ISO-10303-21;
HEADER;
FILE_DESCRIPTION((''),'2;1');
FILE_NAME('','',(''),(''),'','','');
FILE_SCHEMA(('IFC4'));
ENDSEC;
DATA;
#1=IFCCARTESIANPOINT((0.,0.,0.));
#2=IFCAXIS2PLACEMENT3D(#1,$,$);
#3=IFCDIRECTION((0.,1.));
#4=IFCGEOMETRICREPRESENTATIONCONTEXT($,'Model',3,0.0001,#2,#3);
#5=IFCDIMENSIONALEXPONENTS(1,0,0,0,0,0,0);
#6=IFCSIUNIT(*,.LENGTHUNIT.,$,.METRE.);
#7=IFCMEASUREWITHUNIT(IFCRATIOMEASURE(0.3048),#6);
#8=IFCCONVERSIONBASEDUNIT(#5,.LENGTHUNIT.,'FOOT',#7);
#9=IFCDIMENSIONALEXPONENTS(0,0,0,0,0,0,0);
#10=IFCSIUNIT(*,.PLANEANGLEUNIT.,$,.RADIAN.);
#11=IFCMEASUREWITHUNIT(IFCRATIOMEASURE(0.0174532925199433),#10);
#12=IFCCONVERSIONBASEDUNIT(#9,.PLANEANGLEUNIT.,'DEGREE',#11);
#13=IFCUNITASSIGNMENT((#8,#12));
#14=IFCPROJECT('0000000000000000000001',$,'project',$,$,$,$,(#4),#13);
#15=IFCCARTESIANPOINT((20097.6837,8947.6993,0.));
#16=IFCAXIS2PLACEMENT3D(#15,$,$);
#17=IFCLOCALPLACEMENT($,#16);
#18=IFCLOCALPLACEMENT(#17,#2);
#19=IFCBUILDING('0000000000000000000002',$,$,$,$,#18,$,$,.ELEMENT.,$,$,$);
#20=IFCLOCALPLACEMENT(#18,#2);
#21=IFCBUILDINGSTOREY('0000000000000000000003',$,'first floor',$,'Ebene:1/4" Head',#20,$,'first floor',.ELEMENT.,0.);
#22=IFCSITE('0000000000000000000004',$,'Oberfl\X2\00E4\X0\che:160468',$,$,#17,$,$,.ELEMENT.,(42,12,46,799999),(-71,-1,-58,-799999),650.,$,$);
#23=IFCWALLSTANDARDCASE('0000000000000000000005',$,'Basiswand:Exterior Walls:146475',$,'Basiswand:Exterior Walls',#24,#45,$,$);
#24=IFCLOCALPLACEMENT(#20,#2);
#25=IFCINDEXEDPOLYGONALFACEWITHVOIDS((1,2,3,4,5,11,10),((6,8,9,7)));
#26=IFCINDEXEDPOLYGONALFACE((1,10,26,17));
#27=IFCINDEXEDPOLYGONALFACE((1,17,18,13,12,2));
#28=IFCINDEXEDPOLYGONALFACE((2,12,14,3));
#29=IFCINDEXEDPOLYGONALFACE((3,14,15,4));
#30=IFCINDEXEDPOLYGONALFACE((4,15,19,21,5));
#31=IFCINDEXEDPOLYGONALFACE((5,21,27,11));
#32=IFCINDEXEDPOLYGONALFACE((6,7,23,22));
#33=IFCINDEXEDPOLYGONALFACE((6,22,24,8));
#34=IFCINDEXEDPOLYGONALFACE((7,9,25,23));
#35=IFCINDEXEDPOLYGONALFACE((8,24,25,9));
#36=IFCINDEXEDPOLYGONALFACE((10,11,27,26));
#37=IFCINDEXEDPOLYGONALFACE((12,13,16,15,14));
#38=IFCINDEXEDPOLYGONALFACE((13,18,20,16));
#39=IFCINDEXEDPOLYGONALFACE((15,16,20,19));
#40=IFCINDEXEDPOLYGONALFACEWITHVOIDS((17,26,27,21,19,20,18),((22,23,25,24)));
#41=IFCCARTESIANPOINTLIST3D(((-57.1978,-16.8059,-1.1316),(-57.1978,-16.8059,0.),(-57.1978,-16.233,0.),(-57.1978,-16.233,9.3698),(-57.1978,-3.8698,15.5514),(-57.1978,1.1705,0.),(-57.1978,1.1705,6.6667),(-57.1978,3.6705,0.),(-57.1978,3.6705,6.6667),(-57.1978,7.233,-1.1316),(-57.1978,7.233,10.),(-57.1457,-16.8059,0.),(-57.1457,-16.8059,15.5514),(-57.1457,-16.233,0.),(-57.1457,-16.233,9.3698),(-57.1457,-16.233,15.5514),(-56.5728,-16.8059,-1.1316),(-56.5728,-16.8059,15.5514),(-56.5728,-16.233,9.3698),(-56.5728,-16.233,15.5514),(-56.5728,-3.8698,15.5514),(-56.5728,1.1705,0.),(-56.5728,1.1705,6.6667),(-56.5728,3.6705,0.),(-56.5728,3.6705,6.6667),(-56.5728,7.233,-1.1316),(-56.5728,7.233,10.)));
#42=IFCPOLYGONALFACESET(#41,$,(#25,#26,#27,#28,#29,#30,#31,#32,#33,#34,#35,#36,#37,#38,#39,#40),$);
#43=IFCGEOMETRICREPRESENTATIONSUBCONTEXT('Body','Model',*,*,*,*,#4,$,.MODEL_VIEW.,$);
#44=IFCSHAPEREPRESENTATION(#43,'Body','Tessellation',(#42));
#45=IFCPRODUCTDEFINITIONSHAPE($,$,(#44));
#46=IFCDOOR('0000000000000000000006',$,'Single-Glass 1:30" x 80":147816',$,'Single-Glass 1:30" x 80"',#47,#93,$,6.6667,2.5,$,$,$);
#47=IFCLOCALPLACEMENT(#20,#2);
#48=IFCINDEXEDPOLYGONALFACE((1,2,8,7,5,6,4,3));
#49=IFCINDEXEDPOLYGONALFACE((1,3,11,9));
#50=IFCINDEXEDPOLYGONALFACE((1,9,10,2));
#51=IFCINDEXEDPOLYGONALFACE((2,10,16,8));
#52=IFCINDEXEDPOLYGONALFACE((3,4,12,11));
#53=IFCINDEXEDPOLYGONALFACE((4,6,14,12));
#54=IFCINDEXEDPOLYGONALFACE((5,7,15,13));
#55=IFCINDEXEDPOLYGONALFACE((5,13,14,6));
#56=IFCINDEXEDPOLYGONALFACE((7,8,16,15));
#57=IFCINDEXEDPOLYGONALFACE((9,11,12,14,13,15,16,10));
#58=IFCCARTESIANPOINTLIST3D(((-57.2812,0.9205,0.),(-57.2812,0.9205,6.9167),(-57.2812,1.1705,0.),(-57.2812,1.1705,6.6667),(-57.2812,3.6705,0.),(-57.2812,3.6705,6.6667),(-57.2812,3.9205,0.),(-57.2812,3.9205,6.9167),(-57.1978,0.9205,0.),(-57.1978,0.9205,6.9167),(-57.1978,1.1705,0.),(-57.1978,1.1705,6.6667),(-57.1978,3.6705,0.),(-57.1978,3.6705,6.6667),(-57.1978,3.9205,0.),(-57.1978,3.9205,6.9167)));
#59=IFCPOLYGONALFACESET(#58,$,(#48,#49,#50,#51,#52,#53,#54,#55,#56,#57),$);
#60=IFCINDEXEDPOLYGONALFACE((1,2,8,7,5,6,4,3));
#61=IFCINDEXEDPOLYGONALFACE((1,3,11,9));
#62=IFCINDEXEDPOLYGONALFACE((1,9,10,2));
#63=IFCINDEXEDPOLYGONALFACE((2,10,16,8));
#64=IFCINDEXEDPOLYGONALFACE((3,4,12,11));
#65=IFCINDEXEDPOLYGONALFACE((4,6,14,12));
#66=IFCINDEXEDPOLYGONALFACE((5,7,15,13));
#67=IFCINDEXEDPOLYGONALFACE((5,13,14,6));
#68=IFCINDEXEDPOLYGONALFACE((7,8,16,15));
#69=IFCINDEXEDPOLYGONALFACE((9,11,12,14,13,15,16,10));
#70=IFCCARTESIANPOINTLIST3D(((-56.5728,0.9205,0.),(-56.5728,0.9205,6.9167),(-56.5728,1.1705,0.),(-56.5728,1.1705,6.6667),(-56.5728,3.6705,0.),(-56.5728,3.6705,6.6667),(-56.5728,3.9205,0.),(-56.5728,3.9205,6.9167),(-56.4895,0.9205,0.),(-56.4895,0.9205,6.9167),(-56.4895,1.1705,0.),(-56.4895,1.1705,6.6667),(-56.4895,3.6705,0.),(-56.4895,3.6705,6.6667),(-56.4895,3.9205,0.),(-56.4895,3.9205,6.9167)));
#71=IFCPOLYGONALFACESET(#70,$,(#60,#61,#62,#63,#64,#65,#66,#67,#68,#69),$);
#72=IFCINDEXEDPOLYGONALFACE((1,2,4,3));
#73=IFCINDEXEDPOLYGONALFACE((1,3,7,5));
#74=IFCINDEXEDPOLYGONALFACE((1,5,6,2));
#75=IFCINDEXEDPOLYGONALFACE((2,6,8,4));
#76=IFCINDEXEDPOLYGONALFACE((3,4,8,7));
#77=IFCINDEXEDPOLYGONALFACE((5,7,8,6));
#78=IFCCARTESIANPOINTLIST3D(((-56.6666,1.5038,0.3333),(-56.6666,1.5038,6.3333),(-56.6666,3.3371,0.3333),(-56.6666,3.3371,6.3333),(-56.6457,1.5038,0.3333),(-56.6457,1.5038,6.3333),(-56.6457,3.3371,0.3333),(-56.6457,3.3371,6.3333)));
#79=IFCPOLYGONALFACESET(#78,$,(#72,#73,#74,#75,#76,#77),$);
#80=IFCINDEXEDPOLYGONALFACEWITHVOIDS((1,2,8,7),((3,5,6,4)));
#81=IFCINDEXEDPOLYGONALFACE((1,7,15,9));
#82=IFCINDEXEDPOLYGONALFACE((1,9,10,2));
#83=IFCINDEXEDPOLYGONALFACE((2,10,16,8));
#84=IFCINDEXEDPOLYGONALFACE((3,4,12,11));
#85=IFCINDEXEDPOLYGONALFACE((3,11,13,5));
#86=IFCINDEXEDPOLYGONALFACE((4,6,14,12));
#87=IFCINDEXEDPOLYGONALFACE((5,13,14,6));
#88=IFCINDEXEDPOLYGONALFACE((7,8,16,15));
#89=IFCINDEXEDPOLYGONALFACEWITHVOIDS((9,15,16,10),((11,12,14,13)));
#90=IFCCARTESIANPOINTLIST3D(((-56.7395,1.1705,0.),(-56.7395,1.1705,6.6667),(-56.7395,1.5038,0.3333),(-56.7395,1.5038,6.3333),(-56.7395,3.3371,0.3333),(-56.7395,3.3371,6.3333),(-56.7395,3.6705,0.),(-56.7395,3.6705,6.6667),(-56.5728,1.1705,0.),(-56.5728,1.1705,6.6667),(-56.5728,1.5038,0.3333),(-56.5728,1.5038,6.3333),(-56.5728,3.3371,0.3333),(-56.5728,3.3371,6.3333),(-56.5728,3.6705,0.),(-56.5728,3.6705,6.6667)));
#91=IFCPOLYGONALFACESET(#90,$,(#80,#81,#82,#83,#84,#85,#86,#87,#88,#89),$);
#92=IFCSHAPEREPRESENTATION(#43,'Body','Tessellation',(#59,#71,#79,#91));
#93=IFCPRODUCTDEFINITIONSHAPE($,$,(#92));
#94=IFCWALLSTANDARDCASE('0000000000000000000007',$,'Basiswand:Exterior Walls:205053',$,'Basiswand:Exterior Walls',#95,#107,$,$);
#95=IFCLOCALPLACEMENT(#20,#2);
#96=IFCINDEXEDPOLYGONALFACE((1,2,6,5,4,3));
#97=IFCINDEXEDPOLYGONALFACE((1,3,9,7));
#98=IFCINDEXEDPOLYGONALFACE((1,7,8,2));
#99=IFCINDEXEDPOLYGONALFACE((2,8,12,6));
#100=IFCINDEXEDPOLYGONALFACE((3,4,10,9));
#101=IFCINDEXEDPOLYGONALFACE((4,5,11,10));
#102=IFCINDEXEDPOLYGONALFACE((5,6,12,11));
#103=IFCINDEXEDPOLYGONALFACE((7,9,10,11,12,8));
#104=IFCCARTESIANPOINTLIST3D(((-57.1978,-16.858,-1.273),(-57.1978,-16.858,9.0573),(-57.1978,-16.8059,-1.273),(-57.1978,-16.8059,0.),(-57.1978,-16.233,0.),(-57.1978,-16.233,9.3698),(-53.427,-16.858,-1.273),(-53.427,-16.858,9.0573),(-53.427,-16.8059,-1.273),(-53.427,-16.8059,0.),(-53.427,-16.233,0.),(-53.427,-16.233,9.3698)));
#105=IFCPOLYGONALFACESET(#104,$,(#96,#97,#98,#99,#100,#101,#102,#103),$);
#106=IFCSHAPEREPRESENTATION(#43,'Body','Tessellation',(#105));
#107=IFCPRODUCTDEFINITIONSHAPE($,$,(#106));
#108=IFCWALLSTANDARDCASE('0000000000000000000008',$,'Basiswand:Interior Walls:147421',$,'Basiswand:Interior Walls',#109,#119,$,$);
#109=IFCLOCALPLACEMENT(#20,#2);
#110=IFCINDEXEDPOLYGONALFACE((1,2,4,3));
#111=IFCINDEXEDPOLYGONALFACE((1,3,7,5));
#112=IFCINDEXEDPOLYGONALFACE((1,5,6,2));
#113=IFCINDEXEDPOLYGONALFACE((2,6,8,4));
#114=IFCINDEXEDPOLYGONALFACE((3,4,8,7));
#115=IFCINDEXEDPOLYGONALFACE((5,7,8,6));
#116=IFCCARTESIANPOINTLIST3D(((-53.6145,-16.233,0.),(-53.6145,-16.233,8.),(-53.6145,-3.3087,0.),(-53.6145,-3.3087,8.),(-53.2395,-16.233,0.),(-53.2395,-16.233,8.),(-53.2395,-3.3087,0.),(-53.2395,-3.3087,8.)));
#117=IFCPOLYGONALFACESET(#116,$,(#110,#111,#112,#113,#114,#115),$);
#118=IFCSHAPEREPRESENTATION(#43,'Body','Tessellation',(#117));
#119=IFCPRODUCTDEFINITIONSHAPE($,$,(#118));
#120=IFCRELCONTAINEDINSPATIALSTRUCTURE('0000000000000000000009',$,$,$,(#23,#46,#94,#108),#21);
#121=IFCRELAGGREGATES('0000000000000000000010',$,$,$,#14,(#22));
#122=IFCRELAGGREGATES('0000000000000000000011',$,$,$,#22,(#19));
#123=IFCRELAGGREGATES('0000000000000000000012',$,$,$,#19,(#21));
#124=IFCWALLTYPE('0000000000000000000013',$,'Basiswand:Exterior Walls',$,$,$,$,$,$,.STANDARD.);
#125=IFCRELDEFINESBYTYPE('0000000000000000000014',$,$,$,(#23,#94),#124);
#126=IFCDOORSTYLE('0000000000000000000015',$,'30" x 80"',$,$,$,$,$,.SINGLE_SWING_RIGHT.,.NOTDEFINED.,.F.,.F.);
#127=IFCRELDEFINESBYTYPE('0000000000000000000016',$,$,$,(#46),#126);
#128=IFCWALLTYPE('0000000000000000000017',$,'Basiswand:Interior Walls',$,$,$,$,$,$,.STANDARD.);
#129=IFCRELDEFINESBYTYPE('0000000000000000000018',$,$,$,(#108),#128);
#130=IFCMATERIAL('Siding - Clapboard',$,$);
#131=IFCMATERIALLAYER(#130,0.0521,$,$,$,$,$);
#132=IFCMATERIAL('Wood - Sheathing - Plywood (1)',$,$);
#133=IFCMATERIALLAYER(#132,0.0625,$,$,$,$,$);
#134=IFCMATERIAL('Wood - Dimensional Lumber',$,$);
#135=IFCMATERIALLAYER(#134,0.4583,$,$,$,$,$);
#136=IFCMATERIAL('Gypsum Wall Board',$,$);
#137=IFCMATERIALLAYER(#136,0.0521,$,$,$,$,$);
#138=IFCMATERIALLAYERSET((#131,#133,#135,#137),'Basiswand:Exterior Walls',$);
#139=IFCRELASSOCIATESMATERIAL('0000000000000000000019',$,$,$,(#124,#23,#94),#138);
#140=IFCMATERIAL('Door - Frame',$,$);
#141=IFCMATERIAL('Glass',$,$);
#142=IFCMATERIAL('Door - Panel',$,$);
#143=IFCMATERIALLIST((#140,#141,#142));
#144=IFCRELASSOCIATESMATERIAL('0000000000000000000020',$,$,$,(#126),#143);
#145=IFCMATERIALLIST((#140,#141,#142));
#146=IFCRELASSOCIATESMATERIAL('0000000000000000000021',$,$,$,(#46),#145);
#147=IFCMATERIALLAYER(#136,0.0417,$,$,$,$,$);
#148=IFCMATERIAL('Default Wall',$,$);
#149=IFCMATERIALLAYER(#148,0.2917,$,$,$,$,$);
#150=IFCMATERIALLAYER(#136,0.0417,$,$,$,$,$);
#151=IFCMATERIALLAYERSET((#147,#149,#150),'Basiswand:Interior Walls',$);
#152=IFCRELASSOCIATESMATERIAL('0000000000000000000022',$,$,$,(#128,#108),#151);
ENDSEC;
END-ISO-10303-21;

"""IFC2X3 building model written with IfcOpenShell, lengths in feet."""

from ifc_helpers import new_model, entity, si_unit, converted_unit, direction, frame, frame_2d, origin, place, context, subcontext, project, spatial, polyline, rectangle, outline, extrude, clip, bounded_halfspace, source, transform, mapped, material, material_list, layer, layer_set, layer_usage, type_object, type_shapes, element, fill, save


model = new_model("IFC2X3")

# Units and contexts
model_context = context("Model", 3, precision=0.0001, world=origin(), true_north=direction((0.0, 1.0)))
body_context = subcontext(model_context, "Body", "Model", "MODEL_VIEW")
ifc_project = project(units=[converted_unit("LENGTHUNIT", "FOOT", entity("IfcRatioMeasure", 0.3048), si_unit("LENGTHUNIT", "METRE"), dimensions=[1, 0, 0, 0, 0, 0, 0]), converted_unit("PLANEANGLEUNIT", "DEGREE", entity("IfcRatioMeasure", 0.0174532925199433), si_unit("PLANEANGLEUNIT", "RADIAN"), dimensions=[0, 0, 0, 0, 0, 0, 0])], contexts=[model_context])

# Site, building, storey
site_placement = place(None, frame((20097.6837, 8947.6993, 0.0)))
site = spatial("IfcSite", under=ifc_project, at=site_placement, Name="Oberfläche:160468", CompositionType="ELEMENT", RefLatitude=(42, 12, 46, 799999), RefLongitude=(-71, -1, -58, -799999), RefElevation=650.0)
building_placement = place(site_placement, origin())
building = spatial("IfcBuilding", under=site, at=building_placement, CompositionType="ELEMENT")
storey_placement = place(building_placement, origin())
storey = spatial("IfcBuildingStorey", under=building, at=storey_placement, Name="first floor", ObjectType="Ebene:1/4\" Head", LongName="first floor", CompositionType="ELEMENT", Elevation=0.0)

# Wall, opening, door
ifc_material_1 = material(Name="Siding - Clapboard")
ifc_layer_1 = layer(ifc_material_1, 0.0521)
ifc_material_2 = material(Name="Wood - Sheathing - Plywood (1)")
ifc_layer_2 = layer(ifc_material_2, 0.0625)
ifc_material_3 = material(Name="Wood - Dimensional Lumber")
ifc_layer_3 = layer(ifc_material_3, 0.4583)
ifc_material_4 = material(Name="Gypsum Wall Board")
ifc_layer_4 = layer(ifc_material_4, 0.0521)
ifc_layer_set_1 = layer_set([ifc_layer_1, ifc_layer_2, ifc_layer_3, ifc_layer_4], Name="Basiswand:Exterior Walls")
ifc_layer_usage_1 = layer_usage(ifc_layer_set_1, "AXIS2", "NEGATIVE", 0.3125)
wall_type_1 = type_object("IfcWallType", Name="Basiswand:Exterior Walls", PredefinedType="STANDARD", material=ifc_layer_set_1)
wall_1_placement = place(storey_placement, frame((-56.8853, -16.8059, -1.1316), z_axis=(0.0, 0.0, 1.0), x_axis=(0.0, 1.0, 0.0)))
wall_1 = element("IfcWallStandardCase", 1, at=wall_1_placement, inside=storey, type_object=wall_type_1, material=ifc_layer_usage_1, Name="Basiswand:Exterior Walls:146475", ObjectType="Basiswand:Exterior Walls", context=body_context, shape_type="Clipping", body=[
    clip(clip(clip(extrude(rectangle(XDim=24.0388, YDim=0.625, at=frame_2d((12.0194, 0.0), x_axis=(-1.0, 0.0))), origin(), (0.0, 0.0, 1.0), 16.683), bounded_halfspace(frame((12.9361, -0.3125, 16.683), z_axis=(0.447214, 0.0, 0.894427), x_axis=(0.0, 1.0, 0.0)), False, frame((12.9361, -0.3125, 16.683)), polyline([(0.0, 0.0), (10.4778, 0.0), (11.1028, 0.0), (11.1028, 0.625), (0.0, 0.625), (0.0, 0.0)]))), bounded_halfspace(frame((0.5729, -0.3125, 10.5014), z_axis=(-0.447214, 0.0, 0.894427), x_axis=(0.0, -1.0, 0.0)), False, frame((0.5729, -0.3125, 10.5014)), polyline([(0.0, 0.0), (12.3632, 0.0), (12.3632, 0.625), (0.0, 0.625), (0.0, 0.0)]))), bounded_halfspace(frame((0.0, 0.2604, 1.1316)), False, frame((0.0, 0.2604, 1.1316)), polyline([(0.0, 0.0), (0.5729, 0.0), (0.5729, 0.0521), (0.0, 0.0521), (0.0, 0.0)]))),
])
opening_1_placement = place(wall_1_placement, frame((20.4763, 0.3125, 1.1316)))
opening_1 = element("IfcOpeningElement", 2, at=opening_1_placement, cuts=wall_1, ObjectType="Opening", context=body_context, shape_type="SweptSolid", body=[
    extrude(rectangle(XDim=2.5, YDim=6.6667, at=frame_2d((3.3333, 1.25), x_axis=(0.0, 1.0))), frame((0.0, 0.0, 0.0), z_axis=(0.0, -1.0, 0.0), x_axis=(0.0, 0.0, 1.0)), (0.0, 0.0, 1.0), 0.625),
])
ifc_material_5 = material(Name="Door - Frame")
ifc_material_6 = material(Name="Glass")
ifc_material_7 = material(Name="Door - Panel")
ifc_material_list_1 = material_list([ifc_material_5, ifc_material_6, ifc_material_7])
ifc_material_list_2 = material_list([ifc_material_5, ifc_material_6, ifc_material_7])
door_style_1 = type_object("IfcDoorStyle", Name="30\" x 80\"", ConstructionType="NOTDEFINED", OperationType="SINGLE_SWING_RIGHT", ParameterTakesPrecedence=False, Sizeable=False, material=ifc_material_list_2)
shared_shape_1 = source(origin(), body_context, "Body", "SweptSolid", [
    extrude(outline(polyline([(-1.25, -3.2708), (-1.25, 3.3958), (-1.5, 3.3958), (-1.5, -3.5208), (1.5, -3.5208), (1.5, 3.3958), (1.25, 3.3958), (1.25, -3.2708), (-1.25, -3.2708)])), frame((1.25, -0.0833, 3.3958), z_axis=(0.0, -1.0, 0.0), x_axis=(-1.0, 0.0, 0.0)), (0.0, 0.0, -1.0), 0.0833),
    extrude(outline(polyline([(-1.25, -3.2708), (-1.25, 3.3958), (-1.5, 3.3958), (-1.5, -3.5208), (1.5, -3.5208), (1.5, 3.3958), (1.25, 3.3958), (1.25, -3.2708), (-1.25, -3.2708)])), frame((1.25, 0.625, 3.3958), z_axis=(0.0, -1.0, 0.0), x_axis=(-1.0, 0.0, 0.0)), (0.0, 0.0, -1.0), 0.0833),
    extrude(rectangle(XDim=0.0208, YDim=1.8333, at=frame_2d((0.0, 0.0), x_axis=(1.0, 0.0))), frame((1.25, 0.5417, 0.3333), z_axis=(0.0, 0.0, 1.0), x_axis=(0.0, 1.0, 0.0)), (0.0, 0.0, 1.0), 6.0),
    extrude(outline(polyline([(-3.3333, -1.25), (3.3333, -1.25), (3.3333, 1.25), (-3.3333, 1.25), (-3.3333, -1.25)]), holes=[polyline([(-3.0, 0.9167), (3.0, 0.9167), (3.0, -0.9167), (-3.0, -0.9167), (-3.0, 0.9167)])]), frame((1.25, 0.4583, 3.3333), z_axis=(0.0, 1.0, 0.0), x_axis=(0.0, 0.0, -1.0)), (0.0, 0.0, 1.0), 0.1667),
])
type_shapes(door_style_1, [shared_shape_1])
door_1_placement = place(opening_1_placement, frame((0.0, 0.0, 0.0), z_axis=(0.0, 0.0, 1.0), x_axis=(-1.0, 0.0, 0.0)))
door_1 = element("IfcDoor", 3, at=door_1_placement, inside=storey, type_object=door_style_1, material=ifc_material_list_1, Name="Single-Glass 1:30\" x 80\":147816", ObjectType="Single-Glass 1:30\" x 80\"", OverallHeight=6.6667, OverallWidth=2.5, context=body_context, shape_type="MappedRepresentation", body=[
    mapped(shared_shape_1, transform((0.0, 0.0, 0.0), scale=1.0)),
])
fill(opening_1, door_1)

# Walls
ifc_layer_usage_2 = layer_usage(ifc_layer_set_1, "AXIS2", "NEGATIVE", 0.3125)
wall_2_placement = place(storey_placement, frame((-53.427, -16.5455, -1.273), z_axis=(0.0, 0.0, 1.0), x_axis=(-1.0, 0.0, 0.0)))
element("IfcWallStandardCase", 4, at=wall_2_placement, inside=storey, type_object=wall_type_1, material=ifc_layer_usage_2, Name="Basiswand:Exterior Walls:205053", ObjectType="Basiswand:Exterior Walls", context=body_context, shape_type="Clipping", body=[
    clip(clip(extrude(rectangle(XDim=3.7708, YDim=0.625, at=frame_2d((1.8854, 0.0), x_axis=(-1.0, 0.0))), origin(), (0.0, 0.0, 1.0), 10.6428), bounded_halfspace(frame((0.0, -0.3125, 10.6428), z_axis=(0.0, 0.447214, 0.894427), x_axis=(-1.0, 0.0, 0.0)), False, frame((0.0, -0.3125, 10.6428)), polyline([(0.0, 0.0), (3.1458, 0.0), (3.7708, 0.0), (3.7708, 0.625), (0.0, 0.625), (0.0, 0.0)]))), bounded_halfspace(frame((3.7708, -0.3125, 1.273), z_axis=(0.0, 0.0, -1.0), x_axis=(0.0, 1.0, 0.0)), False, frame((3.7708, -0.3125, 1.273)), polyline([(0.0, 0.0), (0.0, 0.5729), (-0.0521, 0.5729), (-3.7708, 0.5729), (-3.7708, 0.0), (-3.5833, 0.0), (-0.625, 0.0), (0.0, 0.0)]))),
])
ifc_layer_5 = layer(ifc_material_4, 0.0417)
ifc_material_8 = material(Name="Default Wall")
ifc_layer_6 = layer(ifc_material_8, 0.2917)
ifc_layer_7 = layer(ifc_material_4, 0.0417)
ifc_layer_set_2 = layer_set([ifc_layer_5, ifc_layer_6, ifc_layer_7], Name="Basiswand:Interior Walls")
ifc_layer_usage_3 = layer_usage(ifc_layer_set_2, "AXIS2", "NEGATIVE", 0.1875)
wall_type_2 = type_object("IfcWallType", Name="Basiswand:Interior Walls", PredefinedType="STANDARD", material=ifc_layer_set_2)
wall_3_placement = place(storey_placement, frame((-53.427, -3.3087, 0.0), z_axis=(0.0, 0.0, 1.0), x_axis=(0.0, -1.0, 0.0)))
element("IfcWallStandardCase", 5, at=wall_3_placement, inside=storey, type_object=wall_type_2, material=ifc_layer_usage_3, Name="Basiswand:Interior Walls:147421", ObjectType="Basiswand:Interior Walls", context=body_context, shape_type="SweptSolid", body=[
    extrude(rectangle(XDim=12.9243, YDim=0.375, at=frame_2d((6.4621, 0.0), x_axis=(-1.0, 0.0))), origin(), (0.0, 0.0, 1.0), 8.0),
])

save(model, "model.ifc")
